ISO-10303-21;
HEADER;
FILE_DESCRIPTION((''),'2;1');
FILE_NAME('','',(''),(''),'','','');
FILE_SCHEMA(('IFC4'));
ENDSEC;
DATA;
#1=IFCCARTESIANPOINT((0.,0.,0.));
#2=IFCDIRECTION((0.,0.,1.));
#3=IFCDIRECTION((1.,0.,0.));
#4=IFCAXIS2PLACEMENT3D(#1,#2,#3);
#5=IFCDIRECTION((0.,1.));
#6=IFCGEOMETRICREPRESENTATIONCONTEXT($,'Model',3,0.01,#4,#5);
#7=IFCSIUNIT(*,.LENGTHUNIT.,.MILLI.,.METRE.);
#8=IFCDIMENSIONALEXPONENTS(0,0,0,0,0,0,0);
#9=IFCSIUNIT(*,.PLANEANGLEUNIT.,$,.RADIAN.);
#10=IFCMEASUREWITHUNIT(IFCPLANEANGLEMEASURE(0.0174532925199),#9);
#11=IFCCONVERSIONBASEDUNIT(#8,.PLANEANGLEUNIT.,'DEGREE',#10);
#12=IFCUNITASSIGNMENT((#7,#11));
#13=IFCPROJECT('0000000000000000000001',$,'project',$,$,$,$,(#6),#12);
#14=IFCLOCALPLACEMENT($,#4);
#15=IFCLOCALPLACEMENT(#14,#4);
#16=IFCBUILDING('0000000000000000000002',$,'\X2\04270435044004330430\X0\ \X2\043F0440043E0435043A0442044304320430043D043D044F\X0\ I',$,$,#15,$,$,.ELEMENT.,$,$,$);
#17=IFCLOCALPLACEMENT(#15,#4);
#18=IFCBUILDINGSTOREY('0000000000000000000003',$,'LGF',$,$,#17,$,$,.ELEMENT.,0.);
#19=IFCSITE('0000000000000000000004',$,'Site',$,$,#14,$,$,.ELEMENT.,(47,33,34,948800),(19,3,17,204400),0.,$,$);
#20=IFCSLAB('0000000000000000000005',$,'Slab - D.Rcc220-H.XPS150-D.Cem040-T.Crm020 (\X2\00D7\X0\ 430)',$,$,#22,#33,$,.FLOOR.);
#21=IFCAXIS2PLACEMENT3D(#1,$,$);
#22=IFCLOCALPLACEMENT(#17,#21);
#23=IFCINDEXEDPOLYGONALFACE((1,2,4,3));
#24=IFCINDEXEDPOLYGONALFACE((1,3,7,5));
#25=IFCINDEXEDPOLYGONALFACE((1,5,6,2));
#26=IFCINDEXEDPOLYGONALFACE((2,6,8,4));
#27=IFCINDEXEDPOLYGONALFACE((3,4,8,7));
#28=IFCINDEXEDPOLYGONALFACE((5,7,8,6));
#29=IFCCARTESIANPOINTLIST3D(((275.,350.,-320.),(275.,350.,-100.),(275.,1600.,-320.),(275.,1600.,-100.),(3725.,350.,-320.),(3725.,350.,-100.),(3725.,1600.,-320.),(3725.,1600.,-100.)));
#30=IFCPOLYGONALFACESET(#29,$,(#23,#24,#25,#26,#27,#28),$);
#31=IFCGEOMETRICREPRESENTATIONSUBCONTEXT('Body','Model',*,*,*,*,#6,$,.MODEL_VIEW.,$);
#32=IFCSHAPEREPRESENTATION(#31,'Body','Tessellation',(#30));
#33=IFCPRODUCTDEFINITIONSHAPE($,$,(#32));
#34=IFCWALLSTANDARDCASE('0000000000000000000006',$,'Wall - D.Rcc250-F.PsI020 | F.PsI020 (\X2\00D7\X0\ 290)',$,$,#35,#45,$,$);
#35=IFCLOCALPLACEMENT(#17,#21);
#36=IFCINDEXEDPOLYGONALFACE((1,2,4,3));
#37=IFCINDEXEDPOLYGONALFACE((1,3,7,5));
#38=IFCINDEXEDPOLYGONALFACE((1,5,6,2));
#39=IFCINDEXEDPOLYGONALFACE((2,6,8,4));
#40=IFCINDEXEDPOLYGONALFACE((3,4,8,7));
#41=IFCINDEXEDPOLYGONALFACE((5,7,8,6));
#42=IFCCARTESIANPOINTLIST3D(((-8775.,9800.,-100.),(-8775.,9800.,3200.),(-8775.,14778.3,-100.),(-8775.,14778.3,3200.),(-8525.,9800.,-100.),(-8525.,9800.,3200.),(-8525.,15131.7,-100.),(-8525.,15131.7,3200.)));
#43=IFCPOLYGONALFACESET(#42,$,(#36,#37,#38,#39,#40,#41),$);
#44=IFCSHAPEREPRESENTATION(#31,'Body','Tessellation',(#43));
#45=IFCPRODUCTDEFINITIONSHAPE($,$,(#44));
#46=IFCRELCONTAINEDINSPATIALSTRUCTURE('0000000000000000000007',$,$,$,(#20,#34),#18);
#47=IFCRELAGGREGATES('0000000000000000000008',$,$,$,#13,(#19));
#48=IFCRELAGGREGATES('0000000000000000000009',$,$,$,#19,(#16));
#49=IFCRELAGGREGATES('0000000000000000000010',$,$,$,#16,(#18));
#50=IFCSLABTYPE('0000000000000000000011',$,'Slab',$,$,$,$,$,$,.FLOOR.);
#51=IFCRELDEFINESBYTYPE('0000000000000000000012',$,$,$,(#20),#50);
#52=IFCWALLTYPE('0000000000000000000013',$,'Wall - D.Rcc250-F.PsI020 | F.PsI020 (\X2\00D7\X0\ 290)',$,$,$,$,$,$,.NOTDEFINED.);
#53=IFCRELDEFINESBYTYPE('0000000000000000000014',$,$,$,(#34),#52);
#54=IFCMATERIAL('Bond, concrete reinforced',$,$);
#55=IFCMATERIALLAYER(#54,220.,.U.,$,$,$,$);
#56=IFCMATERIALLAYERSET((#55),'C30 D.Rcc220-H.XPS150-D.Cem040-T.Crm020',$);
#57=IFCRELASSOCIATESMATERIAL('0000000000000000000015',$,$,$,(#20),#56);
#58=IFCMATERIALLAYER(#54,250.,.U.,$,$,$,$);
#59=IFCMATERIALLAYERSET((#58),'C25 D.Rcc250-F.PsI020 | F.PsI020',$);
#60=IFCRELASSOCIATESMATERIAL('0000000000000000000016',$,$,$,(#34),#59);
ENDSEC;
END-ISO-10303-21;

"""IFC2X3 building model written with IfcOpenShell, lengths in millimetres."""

from ifc_helpers import new_model, entity, si_unit, converted_unit, direction, frame, origin_with_axes, place, context, subcontext, project, spatial, polyline, outline, extrude, material, layer, layer_set, layer_usage, type_object, element, save


model = new_model("IFC2X3")

# Units and contexts
model_context = context("Model", 3, precision=0.01, world=origin_with_axes(), true_north=direction((0.0, 1.0)))
body_context = subcontext(model_context, "Body", "Model", "MODEL_VIEW")
ifc_project = project(units=[si_unit("LENGTHUNIT", "METRE", prefix="MILLI"), converted_unit("PLANEANGLEUNIT", "DEGREE", entity("IfcPlaneAngleMeasure", 0.0174532925199), si_unit("PLANEANGLEUNIT", "RADIAN"), dimensions=[0, 0, 0, 0, 0, 0, 0])], contexts=[model_context])

# Site, building, storey
site_placement = place(None, origin_with_axes())
site = spatial("IfcSite", under=ifc_project, at=site_placement, Name="Site", CompositionType="ELEMENT", RefLatitude=(47, 33, 34, 948800), RefLongitude=(19, 3, 17, 204400), RefElevation=0.0)
building_placement = place(site_placement, origin_with_axes())
building = spatial("IfcBuilding", under=site, at=building_placement, Name="Черга проектування I", CompositionType="ELEMENT")
storey_placement = place(building_placement, origin_with_axes())
storey = spatial("IfcBuildingStorey", under=building, at=storey_placement, Name="LGF", CompositionType="ELEMENT", Elevation=0.0)

# Shared definitions
ifc_material = material(Name="Bond, concrete reinforced")

# Slab
ifc_layer_1 = layer(ifc_material, 220.0, ventilated="UNKNOWN")
ifc_layer_set_1 = layer_set([ifc_layer_1], Name="C30 D.Rcc220-H.XPS150-D.Cem040-T.Crm020")
slab_type = type_object("IfcSlabType", Name="Slab", PredefinedType="FLOOR")
ifc_layer_usage_1 = layer_usage(ifc_layer_set_1, "AXIS3", "NEGATIVE", 220.0)
slab_1_placement = place(storey_placement, frame((275.0, 1600.0, -100.0), z_axis=(0.0, 0.0, 1.0), x_axis=(1.0, 0.0, 0.0)))
element("IfcSlab", 1, at=slab_1_placement, inside=storey, type_object=slab_type, material=ifc_layer_usage_1, Name="Slab - D.Rcc220-H.XPS150-D.Cem040-T.Crm020 (× 430)", PredefinedType="FLOOR", context=body_context, shape_type="SweptSolid", body=[
    extrude(outline(polyline([(0.0, 0.0), (0.0, -1250.0), (3450.0, -1250.0), (3450.0, 0.0), (0.0, 0.0)])), frame((0.0, 0.0, -220.0), z_axis=(0.0, 0.0, 1.0), x_axis=(1.0, 0.0, 0.0)), (0.0, 0.0, 1.0), 220.0),
])

# Wall
ifc_layer_2 = layer(ifc_material, 250.0, ventilated="UNKNOWN")
ifc_layer_set_2 = layer_set([ifc_layer_2], Name="C25 D.Rcc250-F.PsI020 | F.PsI020")
ifc_layer_usage_2 = layer_usage(ifc_layer_set_2, "AXIS2", "NEGATIVE", 250.0)
wall_type_1 = type_object("IfcWallType", Name="Wall - D.Rcc250-F.PsI020 | F.PsI020 (× 290)", PredefinedType="NOTDEFINED")
wall_1_placement = place(storey_placement, frame((-8525.0, 9800.0, -100.0), z_axis=(0.0, 0.0, 1.0), x_axis=(0.0, 1.0, 0.0)))
element("IfcWallStandardCase", 2, at=wall_1_placement, inside=storey, type_object=wall_type_1, material=ifc_layer_usage_2, Name="Wall - D.Rcc250-F.PsI020 | F.PsI020 (× 290)", context=body_context, shape_type="SweptSolid", body=[
    extrude(outline(polyline([(0.0, 0.0), (5331.7, 0.0), (4978.3, 250.0), (0.0, 250.0), (0.0, 0.0)])), origin_with_axes(), (0.0, 0.0, 1.0), 3300.0),
])

save(model, "model.ifc")
